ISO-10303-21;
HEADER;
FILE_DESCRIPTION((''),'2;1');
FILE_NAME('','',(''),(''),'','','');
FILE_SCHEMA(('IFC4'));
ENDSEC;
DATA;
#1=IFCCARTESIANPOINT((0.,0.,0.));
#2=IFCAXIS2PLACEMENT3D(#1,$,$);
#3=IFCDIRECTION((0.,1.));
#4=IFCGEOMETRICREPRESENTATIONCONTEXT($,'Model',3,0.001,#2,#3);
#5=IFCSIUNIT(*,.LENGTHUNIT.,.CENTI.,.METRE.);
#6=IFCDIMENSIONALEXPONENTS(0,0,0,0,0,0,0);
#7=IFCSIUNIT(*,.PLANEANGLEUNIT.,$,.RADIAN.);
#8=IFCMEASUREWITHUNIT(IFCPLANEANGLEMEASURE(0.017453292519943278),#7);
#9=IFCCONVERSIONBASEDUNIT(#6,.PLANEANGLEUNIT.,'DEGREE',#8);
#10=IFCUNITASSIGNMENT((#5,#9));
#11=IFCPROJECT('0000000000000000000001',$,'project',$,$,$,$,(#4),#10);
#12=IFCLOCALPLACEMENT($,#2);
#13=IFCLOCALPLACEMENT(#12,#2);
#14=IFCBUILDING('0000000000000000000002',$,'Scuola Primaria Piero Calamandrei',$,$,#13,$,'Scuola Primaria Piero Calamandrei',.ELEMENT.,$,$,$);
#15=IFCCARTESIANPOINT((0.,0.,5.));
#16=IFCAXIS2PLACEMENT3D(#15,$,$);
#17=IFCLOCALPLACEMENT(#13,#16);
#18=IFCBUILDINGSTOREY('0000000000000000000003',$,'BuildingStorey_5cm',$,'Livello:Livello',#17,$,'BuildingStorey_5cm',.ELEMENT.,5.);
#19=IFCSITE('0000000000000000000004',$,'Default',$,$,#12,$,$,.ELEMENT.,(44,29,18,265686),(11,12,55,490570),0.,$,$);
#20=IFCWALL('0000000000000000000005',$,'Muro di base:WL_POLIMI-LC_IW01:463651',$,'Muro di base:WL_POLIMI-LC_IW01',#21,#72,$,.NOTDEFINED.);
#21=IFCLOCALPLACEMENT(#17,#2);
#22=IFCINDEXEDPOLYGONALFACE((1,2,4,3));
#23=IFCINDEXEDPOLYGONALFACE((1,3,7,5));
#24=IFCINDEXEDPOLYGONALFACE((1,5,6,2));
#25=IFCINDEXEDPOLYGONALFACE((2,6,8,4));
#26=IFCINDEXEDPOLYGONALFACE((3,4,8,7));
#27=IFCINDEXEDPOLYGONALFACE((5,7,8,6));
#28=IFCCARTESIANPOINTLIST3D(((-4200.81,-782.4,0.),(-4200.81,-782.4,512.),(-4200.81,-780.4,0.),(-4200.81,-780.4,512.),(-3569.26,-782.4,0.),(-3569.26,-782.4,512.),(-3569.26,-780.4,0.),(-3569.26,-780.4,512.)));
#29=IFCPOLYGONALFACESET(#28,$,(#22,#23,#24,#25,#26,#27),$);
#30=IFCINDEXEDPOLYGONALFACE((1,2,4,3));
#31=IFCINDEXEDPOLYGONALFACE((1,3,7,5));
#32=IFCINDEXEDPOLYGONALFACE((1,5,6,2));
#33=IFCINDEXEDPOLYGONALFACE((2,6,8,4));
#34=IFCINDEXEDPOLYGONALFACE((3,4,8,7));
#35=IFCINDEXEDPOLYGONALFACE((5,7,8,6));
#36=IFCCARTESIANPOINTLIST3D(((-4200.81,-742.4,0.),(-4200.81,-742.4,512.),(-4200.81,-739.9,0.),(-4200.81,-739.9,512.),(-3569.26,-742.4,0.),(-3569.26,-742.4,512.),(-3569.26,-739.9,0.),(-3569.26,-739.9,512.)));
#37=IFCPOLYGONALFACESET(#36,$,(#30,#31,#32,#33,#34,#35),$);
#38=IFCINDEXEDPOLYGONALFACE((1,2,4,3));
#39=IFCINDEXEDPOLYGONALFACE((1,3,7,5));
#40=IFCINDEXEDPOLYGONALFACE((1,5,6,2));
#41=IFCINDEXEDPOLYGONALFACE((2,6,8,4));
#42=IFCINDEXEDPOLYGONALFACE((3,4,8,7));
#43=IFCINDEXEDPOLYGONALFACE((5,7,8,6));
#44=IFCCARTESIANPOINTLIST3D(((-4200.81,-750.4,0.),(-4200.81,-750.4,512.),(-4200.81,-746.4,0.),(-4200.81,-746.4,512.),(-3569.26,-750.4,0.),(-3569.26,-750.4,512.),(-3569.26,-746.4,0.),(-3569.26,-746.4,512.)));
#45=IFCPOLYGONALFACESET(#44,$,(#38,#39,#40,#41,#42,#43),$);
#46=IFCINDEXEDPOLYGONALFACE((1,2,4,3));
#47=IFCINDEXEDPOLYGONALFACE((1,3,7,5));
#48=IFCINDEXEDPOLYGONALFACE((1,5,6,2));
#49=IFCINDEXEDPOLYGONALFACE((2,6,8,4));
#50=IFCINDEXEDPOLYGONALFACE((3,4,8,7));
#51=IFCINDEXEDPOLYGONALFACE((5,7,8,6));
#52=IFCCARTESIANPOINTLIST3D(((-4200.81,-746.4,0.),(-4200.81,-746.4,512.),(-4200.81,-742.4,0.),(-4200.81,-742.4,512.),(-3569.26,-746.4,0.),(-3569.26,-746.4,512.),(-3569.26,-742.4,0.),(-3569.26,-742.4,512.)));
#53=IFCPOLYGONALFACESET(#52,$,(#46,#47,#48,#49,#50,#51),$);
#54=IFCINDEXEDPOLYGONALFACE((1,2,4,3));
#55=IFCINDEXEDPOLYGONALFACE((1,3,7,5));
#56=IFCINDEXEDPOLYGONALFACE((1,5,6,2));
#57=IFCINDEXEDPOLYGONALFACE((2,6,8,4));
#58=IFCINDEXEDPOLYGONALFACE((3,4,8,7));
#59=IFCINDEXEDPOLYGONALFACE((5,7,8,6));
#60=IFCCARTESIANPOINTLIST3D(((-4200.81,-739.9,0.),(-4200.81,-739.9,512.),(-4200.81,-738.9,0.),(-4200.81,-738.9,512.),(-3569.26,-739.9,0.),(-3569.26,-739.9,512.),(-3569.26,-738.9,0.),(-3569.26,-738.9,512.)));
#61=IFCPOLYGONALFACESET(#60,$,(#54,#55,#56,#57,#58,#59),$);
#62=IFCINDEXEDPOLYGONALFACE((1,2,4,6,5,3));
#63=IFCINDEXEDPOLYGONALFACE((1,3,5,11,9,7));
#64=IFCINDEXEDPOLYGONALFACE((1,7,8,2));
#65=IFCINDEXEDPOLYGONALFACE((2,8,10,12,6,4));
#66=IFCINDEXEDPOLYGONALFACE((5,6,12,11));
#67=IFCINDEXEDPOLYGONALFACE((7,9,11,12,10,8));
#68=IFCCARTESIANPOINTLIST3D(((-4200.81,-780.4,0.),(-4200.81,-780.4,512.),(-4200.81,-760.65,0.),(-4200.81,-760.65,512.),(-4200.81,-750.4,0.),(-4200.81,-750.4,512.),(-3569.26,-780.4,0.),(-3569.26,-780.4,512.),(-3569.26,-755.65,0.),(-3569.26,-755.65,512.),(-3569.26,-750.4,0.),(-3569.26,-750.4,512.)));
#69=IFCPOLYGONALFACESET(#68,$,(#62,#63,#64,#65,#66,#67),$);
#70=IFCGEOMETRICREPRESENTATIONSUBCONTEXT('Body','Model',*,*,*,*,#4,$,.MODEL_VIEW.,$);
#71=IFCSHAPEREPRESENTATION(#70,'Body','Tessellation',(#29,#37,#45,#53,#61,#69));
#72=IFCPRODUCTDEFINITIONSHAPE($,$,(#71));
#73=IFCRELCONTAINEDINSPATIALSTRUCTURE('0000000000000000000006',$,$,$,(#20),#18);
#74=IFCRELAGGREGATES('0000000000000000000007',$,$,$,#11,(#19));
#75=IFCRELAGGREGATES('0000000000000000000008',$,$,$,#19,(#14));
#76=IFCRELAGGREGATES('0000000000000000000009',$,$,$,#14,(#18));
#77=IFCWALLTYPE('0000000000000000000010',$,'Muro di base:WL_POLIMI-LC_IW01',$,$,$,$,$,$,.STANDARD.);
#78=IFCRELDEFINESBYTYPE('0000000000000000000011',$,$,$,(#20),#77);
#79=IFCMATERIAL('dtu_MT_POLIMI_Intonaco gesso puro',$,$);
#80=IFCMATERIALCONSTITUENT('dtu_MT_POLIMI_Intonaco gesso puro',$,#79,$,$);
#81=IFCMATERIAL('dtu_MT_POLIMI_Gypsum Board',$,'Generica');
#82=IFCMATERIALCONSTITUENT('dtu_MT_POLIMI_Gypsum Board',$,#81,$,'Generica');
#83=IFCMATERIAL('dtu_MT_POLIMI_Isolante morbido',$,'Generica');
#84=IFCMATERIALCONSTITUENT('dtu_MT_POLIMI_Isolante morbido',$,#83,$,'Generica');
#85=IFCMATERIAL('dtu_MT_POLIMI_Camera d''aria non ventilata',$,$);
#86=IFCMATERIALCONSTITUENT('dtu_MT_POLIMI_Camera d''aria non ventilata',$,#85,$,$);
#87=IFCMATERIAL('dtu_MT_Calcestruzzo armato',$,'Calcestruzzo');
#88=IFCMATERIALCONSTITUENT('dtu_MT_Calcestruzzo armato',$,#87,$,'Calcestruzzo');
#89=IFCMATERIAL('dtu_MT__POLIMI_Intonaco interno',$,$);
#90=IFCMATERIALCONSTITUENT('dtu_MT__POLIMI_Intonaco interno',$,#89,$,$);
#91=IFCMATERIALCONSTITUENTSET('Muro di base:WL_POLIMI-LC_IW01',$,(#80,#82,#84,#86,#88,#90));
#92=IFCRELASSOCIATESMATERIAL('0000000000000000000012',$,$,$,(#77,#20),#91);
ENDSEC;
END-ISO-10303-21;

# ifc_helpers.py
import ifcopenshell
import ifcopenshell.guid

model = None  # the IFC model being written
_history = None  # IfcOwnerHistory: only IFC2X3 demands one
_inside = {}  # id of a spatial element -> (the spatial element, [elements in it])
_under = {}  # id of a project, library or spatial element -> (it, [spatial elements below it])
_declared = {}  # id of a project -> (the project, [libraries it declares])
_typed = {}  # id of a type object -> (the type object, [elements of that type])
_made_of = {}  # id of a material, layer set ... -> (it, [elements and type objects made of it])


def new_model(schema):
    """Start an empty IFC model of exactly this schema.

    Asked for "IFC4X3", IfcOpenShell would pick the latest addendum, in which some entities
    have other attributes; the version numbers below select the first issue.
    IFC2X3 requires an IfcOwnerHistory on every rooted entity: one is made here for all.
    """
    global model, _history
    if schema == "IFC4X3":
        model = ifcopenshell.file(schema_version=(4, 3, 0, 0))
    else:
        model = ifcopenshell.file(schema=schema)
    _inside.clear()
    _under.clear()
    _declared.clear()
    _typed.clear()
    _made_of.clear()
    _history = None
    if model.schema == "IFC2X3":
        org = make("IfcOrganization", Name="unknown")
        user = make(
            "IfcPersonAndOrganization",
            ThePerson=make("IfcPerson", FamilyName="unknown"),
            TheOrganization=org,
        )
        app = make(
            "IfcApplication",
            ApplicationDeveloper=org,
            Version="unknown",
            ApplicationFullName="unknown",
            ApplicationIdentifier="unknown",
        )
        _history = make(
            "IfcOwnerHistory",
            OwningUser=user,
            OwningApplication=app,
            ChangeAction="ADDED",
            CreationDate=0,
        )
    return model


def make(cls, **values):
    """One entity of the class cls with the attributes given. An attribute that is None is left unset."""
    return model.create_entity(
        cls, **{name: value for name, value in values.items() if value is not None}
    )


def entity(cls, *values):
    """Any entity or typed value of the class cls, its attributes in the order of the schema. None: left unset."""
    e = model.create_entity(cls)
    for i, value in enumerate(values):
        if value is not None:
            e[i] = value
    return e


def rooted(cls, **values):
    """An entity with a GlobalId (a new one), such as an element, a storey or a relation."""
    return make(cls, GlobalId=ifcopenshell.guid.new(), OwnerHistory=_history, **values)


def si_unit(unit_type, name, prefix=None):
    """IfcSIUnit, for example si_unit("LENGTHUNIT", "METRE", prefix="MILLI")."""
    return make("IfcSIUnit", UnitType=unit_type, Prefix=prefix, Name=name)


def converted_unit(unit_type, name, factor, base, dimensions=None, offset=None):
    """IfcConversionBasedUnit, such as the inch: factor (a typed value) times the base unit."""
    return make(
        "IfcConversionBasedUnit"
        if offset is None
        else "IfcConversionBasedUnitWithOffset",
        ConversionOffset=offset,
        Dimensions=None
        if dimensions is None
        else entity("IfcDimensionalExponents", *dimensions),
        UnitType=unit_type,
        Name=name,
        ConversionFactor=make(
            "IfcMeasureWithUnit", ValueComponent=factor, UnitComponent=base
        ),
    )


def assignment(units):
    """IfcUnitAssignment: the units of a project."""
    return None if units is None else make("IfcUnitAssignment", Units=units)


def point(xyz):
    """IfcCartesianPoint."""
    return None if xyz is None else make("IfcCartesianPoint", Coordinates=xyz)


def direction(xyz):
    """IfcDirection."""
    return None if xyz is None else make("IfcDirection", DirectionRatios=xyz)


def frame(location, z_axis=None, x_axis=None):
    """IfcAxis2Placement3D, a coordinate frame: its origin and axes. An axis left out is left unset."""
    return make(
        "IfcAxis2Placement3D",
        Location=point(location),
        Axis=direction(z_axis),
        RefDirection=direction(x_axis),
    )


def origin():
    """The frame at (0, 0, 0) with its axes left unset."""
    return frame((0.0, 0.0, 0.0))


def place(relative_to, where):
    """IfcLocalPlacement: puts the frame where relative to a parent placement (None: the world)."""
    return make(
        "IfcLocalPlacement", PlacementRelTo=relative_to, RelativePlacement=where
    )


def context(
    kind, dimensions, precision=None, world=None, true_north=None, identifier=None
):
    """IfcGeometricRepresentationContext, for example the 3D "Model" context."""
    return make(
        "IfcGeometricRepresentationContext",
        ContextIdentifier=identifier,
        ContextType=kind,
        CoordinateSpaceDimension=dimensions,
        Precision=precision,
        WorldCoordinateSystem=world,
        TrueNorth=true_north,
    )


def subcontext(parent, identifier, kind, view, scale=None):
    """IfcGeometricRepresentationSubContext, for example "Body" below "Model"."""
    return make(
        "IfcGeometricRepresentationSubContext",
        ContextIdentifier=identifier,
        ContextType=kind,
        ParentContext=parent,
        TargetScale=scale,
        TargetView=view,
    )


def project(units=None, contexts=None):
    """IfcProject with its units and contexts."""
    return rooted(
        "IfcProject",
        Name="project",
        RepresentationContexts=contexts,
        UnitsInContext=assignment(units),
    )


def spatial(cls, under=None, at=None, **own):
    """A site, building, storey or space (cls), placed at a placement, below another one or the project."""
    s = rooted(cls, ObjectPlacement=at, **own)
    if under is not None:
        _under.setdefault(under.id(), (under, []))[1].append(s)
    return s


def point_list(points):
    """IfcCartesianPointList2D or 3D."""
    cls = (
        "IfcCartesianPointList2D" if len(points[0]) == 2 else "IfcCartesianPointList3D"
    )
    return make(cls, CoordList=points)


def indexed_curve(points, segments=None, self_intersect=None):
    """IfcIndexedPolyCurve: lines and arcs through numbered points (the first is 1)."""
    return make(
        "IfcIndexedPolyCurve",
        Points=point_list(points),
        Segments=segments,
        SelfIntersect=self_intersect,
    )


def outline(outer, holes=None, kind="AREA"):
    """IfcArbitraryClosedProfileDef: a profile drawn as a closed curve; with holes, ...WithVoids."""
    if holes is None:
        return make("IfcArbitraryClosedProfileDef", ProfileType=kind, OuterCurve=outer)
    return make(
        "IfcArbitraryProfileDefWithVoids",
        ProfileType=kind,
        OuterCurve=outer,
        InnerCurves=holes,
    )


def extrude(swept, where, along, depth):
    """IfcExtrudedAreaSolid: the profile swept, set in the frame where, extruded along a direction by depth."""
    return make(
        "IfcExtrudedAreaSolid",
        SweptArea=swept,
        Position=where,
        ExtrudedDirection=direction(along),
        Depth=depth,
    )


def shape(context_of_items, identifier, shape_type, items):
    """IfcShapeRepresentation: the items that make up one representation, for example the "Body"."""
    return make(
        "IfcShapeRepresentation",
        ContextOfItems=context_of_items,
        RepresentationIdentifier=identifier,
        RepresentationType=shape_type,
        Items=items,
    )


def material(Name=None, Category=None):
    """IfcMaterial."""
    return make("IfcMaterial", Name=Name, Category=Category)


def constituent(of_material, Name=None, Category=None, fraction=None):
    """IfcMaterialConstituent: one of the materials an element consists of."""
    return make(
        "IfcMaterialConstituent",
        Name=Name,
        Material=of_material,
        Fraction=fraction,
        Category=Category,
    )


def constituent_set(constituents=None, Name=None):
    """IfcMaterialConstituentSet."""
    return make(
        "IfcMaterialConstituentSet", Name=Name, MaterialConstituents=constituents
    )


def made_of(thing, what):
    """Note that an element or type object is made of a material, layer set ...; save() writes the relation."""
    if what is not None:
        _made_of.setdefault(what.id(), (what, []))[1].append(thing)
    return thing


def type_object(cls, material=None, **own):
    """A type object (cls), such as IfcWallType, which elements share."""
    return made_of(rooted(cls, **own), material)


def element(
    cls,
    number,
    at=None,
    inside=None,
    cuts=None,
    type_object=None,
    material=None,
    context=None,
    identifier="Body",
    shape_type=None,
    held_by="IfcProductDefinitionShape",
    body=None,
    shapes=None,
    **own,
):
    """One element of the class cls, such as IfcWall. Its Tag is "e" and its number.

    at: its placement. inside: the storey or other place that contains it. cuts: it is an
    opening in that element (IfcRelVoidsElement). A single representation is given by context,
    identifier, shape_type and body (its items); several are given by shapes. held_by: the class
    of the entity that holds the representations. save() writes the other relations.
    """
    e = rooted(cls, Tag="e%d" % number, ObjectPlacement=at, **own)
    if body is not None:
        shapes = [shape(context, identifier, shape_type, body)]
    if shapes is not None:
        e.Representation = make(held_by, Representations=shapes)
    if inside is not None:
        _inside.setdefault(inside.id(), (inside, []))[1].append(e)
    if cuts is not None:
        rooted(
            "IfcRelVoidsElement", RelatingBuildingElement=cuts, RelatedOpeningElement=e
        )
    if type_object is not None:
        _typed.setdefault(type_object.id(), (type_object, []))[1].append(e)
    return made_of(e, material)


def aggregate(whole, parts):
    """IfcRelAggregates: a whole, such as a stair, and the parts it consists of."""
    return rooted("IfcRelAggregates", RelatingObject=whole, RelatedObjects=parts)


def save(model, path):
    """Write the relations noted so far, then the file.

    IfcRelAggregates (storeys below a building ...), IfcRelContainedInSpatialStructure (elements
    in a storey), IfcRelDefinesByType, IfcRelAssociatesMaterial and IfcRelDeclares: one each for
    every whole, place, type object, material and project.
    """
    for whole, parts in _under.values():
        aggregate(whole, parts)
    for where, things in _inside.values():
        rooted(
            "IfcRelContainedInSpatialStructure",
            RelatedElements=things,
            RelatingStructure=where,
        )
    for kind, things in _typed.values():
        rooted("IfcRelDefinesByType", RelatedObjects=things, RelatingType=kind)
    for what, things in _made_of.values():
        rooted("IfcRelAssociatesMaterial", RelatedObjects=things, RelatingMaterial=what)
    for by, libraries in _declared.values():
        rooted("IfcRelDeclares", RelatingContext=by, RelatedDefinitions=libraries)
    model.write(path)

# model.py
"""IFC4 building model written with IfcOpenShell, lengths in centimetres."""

from ifc_helpers import new_model, entity, si_unit, converted_unit, direction, frame, origin, place, context, subcontext, project, spatial, indexed_curve, outline, extrude, material, constituent, constituent_set, type_object, element, save


model = new_model("IFC4")

# Units and contexts
model_context = context("Model", 3, precision=0.001, world=origin(), true_north=direction((0.0, 1.0)))
body_context = subcontext(model_context, "Body", "Model", "MODEL_VIEW")
ifc_project = project(units=[si_unit("LENGTHUNIT", "METRE", prefix="CENTI"), converted_unit("PLANEANGLEUNIT", "DEGREE", entity("IfcPlaneAngleMeasure", 0.017453292519943278), si_unit("PLANEANGLEUNIT", "RADIAN"), dimensions=[0, 0, 0, 0, 0, 0, 0])], contexts=[model_context])

# Site, building, storey
site_placement = place(None, origin())
site = spatial("IfcSite", under=ifc_project, at=site_placement, Name="Default", CompositionType="ELEMENT", RefLatitude=(44, 29, 18, 265686), RefLongitude=(11, 12, 55, 490570), RefElevation=0.0)
building_placement = place(site_placement, origin())
building = spatial("IfcBuilding", under=site, at=building_placement, Name="Scuola Primaria Piero Calamandrei", LongName="Scuola Primaria Piero Calamandrei", CompositionType="ELEMENT")
storey_placement = place(building_placement, frame((0.0, 0.0, 5.0)))
storey = spatial("IfcBuildingStorey", under=building, at=storey_placement, Name="BuildingStorey_5cm", ObjectType="Livello:Livello", LongName="BuildingStorey_5cm", CompositionType="ELEMENT", Elevation=5.0)

# Shared definitions
ifc_material_1 = material(Name="dtu_MT__POLIMI_Intonaco interno")

# Shared definitions
ifc_material_2 = material(Name="dtu_MT_POLIMI_Intonaco gesso puro")

# Shared definitions
ifc_material_3 = material(Name="dtu_MT_POLIMI_Isolante morbido", Category="Generica")
ifc_material_4 = material(Name="dtu_MT_POLIMI_Gypsum Board", Category="Generica")
ifc_material_5 = material(Name="dtu_MT_POLIMI_Camera d'aria non ventilata")

# Wall
ifc_constituent_1 = constituent(ifc_material_2, Name="dtu_MT_POLIMI_Intonaco gesso puro")
ifc_constituent_2 = constituent(ifc_material_4, Name="dtu_MT_POLIMI_Gypsum Board", Category="Generica")
ifc_constituent_3 = constituent(ifc_material_3, Name="dtu_MT_POLIMI_Isolante morbido", Category="Generica")
ifc_constituent_4 = constituent(ifc_material_5, Name="dtu_MT_POLIMI_Camera d'aria non ventilata")
ifc_material_6 = material(Name="dtu_MT_Calcestruzzo armato", Category="Calcestruzzo")
ifc_constituent_5 = constituent(ifc_material_6, Name="dtu_MT_Calcestruzzo armato", Category="Calcestruzzo")
ifc_constituent_6 = constituent(ifc_material_1, Name="dtu_MT__POLIMI_Intonaco interno")
ifc_constituent_set_1 = constituent_set(constituents=[ifc_constituent_1, ifc_constituent_2, ifc_constituent_3, ifc_constituent_4, ifc_constituent_5, ifc_constituent_6], Name="Muro di base:WL_POLIMI-LC_IW01")
wall_type_1 = type_object("IfcWallType", Name="Muro di base:WL_POLIMI-LC_IW01", PredefinedType="STANDARD", material=ifc_constituent_set_1)
wall_1_placement = place(storey_placement, frame((-4200.81, -760.65, 0.0)))
element("IfcWall", 1, at=wall_1_placement, inside=storey, type_object=wall_type_1, material=ifc_constituent_set_1, Name="Muro di base:WL_POLIMI-LC_IW01:463651", ObjectType="Muro di base:WL_POLIMI-LC_IW01", PredefinedType="NOTDEFINED", context=body_context, shape_type="SweptSolid", body=[
    extrude(outline(indexed_curve([(-1.0, -315.78), (1.0, -315.78), (1.0, 315.78), (-1.0, 315.78), (-1.0, -315.78)], self_intersect=False)), frame((315.78, -20.75, 0.0), z_axis=(0.0, 0.0, 1.0), x_axis=(0.0, 1.0, 0.0)), (0.0, 0.0, 1.0), 512.0),
    extrude(outline(indexed_curve([(-315.78, -1.25), (315.78, -1.25), (315.78, 1.25), (-315.78, 1.25), (-315.78, -1.25)], self_intersect=False)), frame((315.78, 19.5, 0.0)), (0.0, 0.0, 1.0), 512.0),
    extrude(outline(indexed_curve([(-315.78, -2.0), (315.78, -2.0), (315.78, 2.0), (-315.78, 2.0), (-315.78, -2.0)], self_intersect=False)), frame((315.78, 12.25, 0.0)), (0.0, 0.0, 1.0), 512.0),
    extrude(outline(indexed_curve([(-315.78, -2.0), (315.78, -2.0), (315.78, 2.0), (-315.78, 2.0), (-315.78, -2.0)], self_intersect=False)), frame((315.78, 16.25, 0.0)), (0.0, 0.0, 1.0), 512.0),
    extrude(outline(indexed_curve([(-0.5, -315.78), (0.5, -315.78), (0.5, 315.78), (-0.5, 315.78), (-0.5, -315.78)], self_intersect=False)), frame((315.78, 21.25, 0.0), z_axis=(0.0, 0.0, 1.0), x_axis=(0.0, -1.0, 0.0)), (0.0, 0.0, 1.0), 512.0),
    extrude(outline(indexed_curve([(-315.78, -17.42), (315.78, -17.42), (315.78, 7.33), (315.78, 12.58), (-315.78, 12.58), (-315.78, 2.33), (-315.78, -17.42)], self_intersect=False)), frame((315.78, -2.33, 0.0)), (0.0, 0.0, 1.0), 512.0),
])

save(model, "model.ifc")
